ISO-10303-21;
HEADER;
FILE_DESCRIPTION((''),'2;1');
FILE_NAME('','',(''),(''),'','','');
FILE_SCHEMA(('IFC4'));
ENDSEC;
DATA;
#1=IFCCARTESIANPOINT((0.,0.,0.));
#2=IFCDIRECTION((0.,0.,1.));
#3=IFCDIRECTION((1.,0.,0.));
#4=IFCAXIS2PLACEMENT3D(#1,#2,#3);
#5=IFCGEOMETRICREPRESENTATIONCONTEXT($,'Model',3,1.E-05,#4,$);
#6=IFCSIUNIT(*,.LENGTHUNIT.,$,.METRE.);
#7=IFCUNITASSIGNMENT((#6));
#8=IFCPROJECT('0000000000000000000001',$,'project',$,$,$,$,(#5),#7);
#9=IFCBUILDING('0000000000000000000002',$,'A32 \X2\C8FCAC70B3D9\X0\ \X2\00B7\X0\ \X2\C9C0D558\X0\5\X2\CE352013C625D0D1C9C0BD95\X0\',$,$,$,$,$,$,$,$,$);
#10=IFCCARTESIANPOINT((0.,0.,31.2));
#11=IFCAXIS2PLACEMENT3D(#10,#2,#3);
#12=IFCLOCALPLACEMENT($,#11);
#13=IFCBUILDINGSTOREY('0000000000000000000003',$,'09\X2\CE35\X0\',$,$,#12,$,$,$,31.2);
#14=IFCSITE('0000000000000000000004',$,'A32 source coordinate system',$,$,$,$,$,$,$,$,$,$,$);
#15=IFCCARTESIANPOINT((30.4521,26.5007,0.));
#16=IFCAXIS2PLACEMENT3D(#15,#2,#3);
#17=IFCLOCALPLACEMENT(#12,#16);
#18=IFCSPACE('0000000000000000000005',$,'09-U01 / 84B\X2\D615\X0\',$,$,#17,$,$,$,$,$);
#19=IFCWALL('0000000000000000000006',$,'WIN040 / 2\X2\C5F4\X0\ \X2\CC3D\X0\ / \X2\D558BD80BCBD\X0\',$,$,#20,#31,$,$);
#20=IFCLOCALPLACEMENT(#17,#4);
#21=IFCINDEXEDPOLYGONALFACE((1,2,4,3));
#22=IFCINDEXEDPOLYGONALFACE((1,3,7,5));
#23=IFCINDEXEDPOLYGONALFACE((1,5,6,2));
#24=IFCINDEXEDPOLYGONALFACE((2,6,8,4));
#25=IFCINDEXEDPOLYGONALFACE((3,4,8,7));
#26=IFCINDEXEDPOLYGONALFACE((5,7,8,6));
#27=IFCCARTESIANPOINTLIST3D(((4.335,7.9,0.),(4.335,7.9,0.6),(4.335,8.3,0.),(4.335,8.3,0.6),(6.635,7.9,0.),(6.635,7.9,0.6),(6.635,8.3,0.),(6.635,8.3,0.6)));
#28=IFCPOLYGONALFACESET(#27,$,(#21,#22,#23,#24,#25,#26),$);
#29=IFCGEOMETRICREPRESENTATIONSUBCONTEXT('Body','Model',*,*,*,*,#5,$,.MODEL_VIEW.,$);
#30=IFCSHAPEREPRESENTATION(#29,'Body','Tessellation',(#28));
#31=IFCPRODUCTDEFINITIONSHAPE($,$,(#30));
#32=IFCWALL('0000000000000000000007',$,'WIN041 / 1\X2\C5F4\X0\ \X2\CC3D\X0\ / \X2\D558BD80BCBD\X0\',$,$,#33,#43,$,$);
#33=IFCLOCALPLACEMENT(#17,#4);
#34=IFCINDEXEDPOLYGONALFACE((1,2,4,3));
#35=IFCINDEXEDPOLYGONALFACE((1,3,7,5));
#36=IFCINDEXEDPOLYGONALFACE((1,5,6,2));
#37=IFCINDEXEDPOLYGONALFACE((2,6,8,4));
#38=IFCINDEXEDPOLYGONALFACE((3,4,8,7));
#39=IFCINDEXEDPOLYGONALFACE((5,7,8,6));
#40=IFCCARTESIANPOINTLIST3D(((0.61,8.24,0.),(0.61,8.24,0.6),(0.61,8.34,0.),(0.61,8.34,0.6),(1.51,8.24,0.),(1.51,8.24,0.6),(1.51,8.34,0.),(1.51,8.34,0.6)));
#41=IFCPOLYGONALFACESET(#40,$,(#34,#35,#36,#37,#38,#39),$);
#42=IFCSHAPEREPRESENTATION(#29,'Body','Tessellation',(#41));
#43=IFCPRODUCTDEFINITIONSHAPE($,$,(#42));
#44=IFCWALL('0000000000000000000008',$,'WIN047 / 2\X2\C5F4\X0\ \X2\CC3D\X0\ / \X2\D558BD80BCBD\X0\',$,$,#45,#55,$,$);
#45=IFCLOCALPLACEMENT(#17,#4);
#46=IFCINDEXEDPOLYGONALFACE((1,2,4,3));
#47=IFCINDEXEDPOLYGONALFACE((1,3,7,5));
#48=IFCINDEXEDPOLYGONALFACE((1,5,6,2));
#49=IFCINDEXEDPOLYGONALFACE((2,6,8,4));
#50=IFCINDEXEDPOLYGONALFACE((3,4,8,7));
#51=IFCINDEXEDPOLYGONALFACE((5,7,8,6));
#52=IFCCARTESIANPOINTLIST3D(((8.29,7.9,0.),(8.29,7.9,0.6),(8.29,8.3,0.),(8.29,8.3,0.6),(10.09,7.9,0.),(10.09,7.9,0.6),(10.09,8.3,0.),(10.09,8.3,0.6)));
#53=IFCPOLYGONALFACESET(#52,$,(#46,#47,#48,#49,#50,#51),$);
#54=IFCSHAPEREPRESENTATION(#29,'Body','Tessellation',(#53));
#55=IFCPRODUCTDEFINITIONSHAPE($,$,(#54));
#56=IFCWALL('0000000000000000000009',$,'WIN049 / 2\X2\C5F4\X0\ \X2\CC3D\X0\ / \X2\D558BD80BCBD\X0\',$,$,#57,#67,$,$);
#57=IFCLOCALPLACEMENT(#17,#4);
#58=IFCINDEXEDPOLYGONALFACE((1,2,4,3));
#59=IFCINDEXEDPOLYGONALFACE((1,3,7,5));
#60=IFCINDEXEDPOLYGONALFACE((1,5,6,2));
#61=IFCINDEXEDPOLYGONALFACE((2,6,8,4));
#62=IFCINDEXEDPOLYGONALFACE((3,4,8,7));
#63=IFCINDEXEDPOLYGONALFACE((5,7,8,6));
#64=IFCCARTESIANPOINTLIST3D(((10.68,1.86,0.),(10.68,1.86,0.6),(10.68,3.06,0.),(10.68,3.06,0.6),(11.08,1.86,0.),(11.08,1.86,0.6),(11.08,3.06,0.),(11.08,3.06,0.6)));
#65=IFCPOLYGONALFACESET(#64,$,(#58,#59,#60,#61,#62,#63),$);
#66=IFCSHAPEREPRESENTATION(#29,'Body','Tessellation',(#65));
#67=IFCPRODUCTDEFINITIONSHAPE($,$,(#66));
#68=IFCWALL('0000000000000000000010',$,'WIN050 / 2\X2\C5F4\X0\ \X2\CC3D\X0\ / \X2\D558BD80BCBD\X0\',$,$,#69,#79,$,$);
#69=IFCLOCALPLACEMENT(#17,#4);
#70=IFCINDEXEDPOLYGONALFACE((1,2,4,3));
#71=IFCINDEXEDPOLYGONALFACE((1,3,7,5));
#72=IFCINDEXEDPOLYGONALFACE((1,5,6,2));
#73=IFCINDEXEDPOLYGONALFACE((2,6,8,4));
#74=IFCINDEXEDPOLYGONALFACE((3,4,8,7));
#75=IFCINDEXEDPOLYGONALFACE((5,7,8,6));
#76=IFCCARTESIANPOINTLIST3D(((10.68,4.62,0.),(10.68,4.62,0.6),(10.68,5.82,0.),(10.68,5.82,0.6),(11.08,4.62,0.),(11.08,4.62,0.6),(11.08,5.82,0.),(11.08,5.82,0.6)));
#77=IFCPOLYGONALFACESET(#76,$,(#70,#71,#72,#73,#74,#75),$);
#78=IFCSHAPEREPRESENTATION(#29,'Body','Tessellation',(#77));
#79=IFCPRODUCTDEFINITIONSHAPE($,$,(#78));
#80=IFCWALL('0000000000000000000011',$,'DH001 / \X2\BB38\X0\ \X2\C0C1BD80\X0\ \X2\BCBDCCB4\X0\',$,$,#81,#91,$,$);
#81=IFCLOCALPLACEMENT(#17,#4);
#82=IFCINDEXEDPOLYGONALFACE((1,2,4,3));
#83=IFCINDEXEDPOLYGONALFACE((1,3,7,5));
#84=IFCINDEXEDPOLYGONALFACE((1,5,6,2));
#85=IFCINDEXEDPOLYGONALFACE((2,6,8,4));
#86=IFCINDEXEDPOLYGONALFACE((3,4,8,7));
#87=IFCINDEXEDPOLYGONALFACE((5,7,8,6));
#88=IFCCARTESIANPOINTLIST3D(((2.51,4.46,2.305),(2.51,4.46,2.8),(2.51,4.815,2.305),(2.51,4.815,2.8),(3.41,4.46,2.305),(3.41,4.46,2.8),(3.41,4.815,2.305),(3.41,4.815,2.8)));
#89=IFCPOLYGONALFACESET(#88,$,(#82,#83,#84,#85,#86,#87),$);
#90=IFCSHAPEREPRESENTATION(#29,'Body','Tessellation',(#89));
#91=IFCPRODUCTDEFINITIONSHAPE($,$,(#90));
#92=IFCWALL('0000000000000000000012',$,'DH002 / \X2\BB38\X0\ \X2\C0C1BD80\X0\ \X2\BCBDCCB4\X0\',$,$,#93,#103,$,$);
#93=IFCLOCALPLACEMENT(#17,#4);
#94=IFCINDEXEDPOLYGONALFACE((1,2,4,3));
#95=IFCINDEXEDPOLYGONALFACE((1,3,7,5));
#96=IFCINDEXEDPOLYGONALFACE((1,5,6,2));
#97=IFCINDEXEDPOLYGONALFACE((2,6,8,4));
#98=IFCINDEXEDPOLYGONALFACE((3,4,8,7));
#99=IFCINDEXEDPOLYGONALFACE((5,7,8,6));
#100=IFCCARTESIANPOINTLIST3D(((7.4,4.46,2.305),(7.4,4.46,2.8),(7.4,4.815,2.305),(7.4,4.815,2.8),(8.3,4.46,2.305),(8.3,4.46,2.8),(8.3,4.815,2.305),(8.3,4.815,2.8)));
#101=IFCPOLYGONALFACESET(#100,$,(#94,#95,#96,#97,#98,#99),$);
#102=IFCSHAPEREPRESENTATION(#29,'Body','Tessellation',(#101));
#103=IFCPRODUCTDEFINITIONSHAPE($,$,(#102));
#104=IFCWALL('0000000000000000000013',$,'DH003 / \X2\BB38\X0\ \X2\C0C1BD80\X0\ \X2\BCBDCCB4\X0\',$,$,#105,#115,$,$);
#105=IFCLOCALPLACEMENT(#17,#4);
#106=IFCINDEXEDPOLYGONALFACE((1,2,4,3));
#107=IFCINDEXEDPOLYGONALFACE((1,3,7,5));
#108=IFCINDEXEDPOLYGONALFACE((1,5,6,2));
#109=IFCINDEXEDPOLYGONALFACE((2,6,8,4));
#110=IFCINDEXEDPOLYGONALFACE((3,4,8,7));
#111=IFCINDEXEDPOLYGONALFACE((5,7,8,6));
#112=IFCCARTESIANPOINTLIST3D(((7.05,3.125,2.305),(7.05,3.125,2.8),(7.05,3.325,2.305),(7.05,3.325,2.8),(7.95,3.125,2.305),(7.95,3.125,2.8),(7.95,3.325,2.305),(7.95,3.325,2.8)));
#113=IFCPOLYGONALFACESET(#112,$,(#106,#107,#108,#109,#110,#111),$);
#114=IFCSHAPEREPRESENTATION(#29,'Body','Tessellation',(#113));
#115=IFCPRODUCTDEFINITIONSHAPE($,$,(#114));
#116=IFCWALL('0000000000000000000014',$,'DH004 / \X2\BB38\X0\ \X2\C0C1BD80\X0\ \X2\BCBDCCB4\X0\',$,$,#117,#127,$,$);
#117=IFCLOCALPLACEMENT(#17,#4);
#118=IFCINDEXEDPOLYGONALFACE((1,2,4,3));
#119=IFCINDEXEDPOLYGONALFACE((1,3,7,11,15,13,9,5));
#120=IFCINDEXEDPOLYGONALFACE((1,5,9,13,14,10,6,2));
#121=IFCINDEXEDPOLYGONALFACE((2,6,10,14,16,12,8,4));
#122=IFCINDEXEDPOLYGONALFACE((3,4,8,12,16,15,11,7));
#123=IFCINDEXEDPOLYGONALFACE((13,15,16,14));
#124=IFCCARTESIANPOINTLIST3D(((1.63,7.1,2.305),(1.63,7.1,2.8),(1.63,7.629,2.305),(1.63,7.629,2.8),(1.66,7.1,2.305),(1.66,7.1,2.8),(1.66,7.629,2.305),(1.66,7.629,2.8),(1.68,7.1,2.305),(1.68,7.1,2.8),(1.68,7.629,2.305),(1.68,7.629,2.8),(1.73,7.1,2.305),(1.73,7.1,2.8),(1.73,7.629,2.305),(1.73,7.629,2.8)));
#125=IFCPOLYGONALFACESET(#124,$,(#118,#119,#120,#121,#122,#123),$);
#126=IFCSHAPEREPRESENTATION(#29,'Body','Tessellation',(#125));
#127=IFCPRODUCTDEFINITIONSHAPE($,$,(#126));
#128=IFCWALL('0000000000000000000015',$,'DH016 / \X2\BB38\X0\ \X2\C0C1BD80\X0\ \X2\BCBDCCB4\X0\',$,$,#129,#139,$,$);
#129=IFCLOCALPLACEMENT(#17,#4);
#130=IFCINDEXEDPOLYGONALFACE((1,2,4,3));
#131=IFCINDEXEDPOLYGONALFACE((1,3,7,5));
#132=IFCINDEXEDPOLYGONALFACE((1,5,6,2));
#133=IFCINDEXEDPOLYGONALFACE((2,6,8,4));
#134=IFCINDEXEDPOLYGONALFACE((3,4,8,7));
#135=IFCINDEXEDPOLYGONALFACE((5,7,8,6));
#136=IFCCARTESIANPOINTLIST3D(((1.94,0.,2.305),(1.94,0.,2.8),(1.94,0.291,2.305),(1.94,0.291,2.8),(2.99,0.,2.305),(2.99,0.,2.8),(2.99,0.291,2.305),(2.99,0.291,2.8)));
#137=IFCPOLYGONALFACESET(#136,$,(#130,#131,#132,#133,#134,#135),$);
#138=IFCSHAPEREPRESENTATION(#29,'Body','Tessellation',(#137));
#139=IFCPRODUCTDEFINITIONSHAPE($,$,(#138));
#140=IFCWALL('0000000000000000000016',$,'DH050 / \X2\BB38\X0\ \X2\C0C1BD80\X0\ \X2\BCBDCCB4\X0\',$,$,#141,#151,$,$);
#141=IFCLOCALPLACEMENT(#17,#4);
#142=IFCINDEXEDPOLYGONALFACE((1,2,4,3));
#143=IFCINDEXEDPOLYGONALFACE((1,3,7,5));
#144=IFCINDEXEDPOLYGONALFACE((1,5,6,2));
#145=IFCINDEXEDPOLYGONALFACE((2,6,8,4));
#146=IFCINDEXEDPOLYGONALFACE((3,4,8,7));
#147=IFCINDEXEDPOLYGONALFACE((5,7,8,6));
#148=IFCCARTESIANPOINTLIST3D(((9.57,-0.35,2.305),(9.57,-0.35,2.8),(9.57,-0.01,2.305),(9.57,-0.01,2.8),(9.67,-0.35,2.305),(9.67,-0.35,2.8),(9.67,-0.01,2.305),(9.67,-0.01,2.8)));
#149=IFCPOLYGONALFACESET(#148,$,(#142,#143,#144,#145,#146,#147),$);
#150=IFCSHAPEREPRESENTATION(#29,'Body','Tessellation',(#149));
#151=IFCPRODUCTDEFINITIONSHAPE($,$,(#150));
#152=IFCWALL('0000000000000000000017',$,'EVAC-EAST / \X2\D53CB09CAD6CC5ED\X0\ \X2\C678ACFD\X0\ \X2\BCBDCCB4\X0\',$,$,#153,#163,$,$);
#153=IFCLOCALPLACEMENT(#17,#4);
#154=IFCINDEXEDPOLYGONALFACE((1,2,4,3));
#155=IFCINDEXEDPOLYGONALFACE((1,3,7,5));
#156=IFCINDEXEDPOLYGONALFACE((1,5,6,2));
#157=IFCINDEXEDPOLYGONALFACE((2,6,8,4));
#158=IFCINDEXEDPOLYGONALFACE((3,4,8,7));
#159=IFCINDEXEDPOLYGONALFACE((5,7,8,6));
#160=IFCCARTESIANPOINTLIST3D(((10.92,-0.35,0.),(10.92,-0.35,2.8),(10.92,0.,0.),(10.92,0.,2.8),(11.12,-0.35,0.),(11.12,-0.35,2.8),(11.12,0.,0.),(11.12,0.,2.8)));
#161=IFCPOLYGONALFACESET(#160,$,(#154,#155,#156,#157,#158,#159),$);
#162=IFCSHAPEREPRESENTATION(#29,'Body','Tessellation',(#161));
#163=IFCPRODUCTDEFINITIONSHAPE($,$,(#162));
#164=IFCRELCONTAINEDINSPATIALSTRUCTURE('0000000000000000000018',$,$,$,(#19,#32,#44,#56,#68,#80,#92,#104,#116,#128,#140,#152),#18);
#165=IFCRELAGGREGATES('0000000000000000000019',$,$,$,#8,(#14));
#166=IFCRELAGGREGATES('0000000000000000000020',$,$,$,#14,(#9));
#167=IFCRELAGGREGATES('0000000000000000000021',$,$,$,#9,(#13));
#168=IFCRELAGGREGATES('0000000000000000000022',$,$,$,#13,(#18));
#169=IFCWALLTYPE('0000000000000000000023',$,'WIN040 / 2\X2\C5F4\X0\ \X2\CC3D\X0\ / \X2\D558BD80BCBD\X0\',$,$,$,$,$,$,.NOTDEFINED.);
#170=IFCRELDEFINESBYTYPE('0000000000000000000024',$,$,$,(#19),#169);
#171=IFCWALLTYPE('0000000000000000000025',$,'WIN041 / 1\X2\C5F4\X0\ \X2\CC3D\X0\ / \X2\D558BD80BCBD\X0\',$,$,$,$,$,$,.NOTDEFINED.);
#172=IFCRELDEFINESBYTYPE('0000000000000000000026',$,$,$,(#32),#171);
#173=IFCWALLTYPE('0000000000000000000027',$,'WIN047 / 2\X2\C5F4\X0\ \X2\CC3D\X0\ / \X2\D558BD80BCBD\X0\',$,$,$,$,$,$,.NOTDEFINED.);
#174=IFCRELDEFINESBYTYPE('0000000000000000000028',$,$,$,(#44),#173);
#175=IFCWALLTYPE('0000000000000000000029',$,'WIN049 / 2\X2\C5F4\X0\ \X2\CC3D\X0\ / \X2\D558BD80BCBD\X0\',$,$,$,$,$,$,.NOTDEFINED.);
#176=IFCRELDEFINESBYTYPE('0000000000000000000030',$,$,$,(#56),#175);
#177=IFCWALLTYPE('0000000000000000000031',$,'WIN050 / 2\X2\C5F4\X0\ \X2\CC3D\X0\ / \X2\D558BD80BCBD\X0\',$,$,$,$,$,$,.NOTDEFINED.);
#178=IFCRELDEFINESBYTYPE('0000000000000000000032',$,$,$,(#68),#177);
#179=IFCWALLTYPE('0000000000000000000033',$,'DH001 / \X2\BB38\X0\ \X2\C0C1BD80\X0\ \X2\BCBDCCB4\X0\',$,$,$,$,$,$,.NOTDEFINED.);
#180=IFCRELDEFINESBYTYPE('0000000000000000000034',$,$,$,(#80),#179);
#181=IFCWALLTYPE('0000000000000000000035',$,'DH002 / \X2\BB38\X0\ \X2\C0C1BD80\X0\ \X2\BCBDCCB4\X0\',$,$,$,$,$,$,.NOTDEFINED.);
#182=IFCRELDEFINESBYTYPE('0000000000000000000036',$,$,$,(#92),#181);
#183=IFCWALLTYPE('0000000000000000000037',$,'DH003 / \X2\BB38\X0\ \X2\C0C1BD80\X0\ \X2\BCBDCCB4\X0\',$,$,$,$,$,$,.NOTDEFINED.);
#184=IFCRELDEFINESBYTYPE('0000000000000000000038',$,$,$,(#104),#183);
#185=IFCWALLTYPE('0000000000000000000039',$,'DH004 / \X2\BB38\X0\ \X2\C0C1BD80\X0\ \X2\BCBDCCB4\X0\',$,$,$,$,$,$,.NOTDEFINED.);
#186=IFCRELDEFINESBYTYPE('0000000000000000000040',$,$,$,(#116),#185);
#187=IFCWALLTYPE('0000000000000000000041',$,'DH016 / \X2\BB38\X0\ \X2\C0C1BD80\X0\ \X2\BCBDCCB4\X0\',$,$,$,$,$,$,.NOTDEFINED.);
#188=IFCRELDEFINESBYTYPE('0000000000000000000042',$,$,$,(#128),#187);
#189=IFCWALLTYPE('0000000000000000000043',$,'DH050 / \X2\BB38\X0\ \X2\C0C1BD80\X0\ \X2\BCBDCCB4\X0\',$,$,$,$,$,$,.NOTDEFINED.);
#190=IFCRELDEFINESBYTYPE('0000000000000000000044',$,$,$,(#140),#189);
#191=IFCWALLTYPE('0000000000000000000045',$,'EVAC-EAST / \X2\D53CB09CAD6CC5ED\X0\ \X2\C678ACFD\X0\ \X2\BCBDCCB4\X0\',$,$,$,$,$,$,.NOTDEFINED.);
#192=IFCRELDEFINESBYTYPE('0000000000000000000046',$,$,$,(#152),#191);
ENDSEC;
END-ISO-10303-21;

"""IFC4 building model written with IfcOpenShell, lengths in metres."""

from ifc_helpers import new_model, si_unit, frame, origin, origin_with_axes, place, context, subcontext, project, spatial, polyline, outline, extrude, source, transform, mapped, type_object, type_shapes, element, save


model = new_model("IFC4")

# Units and contexts
model_context = context("Model", 3, precision=1e-05, world=origin_with_axes())
body_context = subcontext(model_context, "Body", "Model", "MODEL_VIEW")
ifc_project = project(units=[si_unit("LENGTHUNIT", "METRE")], contexts=[model_context])

# Site, building, storey, space
site = spatial("IfcSite", under=ifc_project, Name="A32 source coordinate system")
building = spatial("IfcBuilding", under=site, Name="A32 주거동 · 지하5층–옥탑지붕")
storey_placement = place(None, frame((0.0, 0.0, 31.2), z_axis=(0.0, 0.0, 1.0), x_axis=(1.0, 0.0, 0.0)))
storey = spatial("IfcBuildingStorey", under=building, at=storey_placement, Name="09층", Elevation=31.2)
space_placement = place(storey_placement, frame((30.4521, 26.5007, 0.0), z_axis=(0.0, 0.0, 1.0), x_axis=(1.0, 0.0, 0.0)))
space = spatial("IfcSpace", under=storey, at=space_placement, Name="09-U01 / 84B형")

# Walls
wall_type_1 = type_object("IfcWallType", Name="WIN040 / 2열 창 / 하부벽", PredefinedType="NOTDEFINED")
shared_shape_1 = source(origin(), body_context, "Body", "SweptSolid", [
    extrude(outline(polyline([(4.335, 8.3), (6.635, 8.3), (6.635, 7.9), (4.335, 7.9), (4.335, 8.3)])), origin(), (0.0, 0.0, 1.0), 0.6),
])
type_shapes(wall_type_1, [shared_shape_1])
wall_1_placement = place(space_placement, origin_with_axes())
element("IfcWall", 1, at=wall_1_placement, inside=space, type_object=wall_type_1, Name="WIN040 / 2열 창 / 하부벽", context=body_context, shape_type="MappedRepresentation", body=[
    mapped(shared_shape_1, transform((0.0, 0.0, 0.0), scale=1.0)),
])
wall_type_2 = type_object("IfcWallType", Name="WIN041 / 1열 창 / 하부벽", PredefinedType="NOTDEFINED")
shared_shape_2 = source(origin(), body_context, "Body", "SweptSolid", [
    extrude(outline(polyline([(0.61, 8.34), (1.51, 8.34), (1.51, 8.24), (0.61, 8.24), (0.61, 8.34)])), origin(), (0.0, 0.0, 1.0), 0.6),
])
type_shapes(wall_type_2, [shared_shape_2])
wall_2_placement = place(space_placement, origin_with_axes())
element("IfcWall", 2, at=wall_2_placement, inside=space, type_object=wall_type_2, Name="WIN041 / 1열 창 / 하부벽", context=body_context, shape_type="MappedRepresentation", body=[
    mapped(shared_shape_2, transform((0.0, 0.0, 0.0), scale=1.0)),
])
wall_type_3 = type_object("IfcWallType", Name="WIN047 / 2열 창 / 하부벽", PredefinedType="NOTDEFINED")
shared_shape_3 = source(origin(), body_context, "Body", "SweptSolid", [
    extrude(outline(polyline([(8.29, 8.3), (10.09, 8.3), (10.09, 7.9), (8.29, 7.9), (8.29, 8.3)])), origin(), (0.0, 0.0, 1.0), 0.6),
])
type_shapes(wall_type_3, [shared_shape_3])
wall_3_placement = place(space_placement, origin_with_axes())
element("IfcWall", 3, at=wall_3_placement, inside=space, type_object=wall_type_3, Name="WIN047 / 2열 창 / 하부벽", context=body_context, shape_type="MappedRepresentation", body=[
    mapped(shared_shape_3, transform((0.0, 0.0, 0.0), scale=1.0)),
])
wall_type_4 = type_object("IfcWallType", Name="WIN049 / 2열 창 / 하부벽", PredefinedType="NOTDEFINED")
shared_shape_4 = source(origin(), body_context, "Body", "SweptSolid", [
    extrude(outline(polyline([(10.68, 3.06), (11.08, 3.06), (11.08, 1.86), (10.68, 1.86), (10.68, 3.06)])), origin(), (0.0, 0.0, 1.0), 0.6),
])
type_shapes(wall_type_4, [shared_shape_4])
wall_4_placement = place(space_placement, origin_with_axes())
element("IfcWall", 4, at=wall_4_placement, inside=space, type_object=wall_type_4, Name="WIN049 / 2열 창 / 하부벽", context=body_context, shape_type="MappedRepresentation", body=[
    mapped(shared_shape_4, transform((0.0, 0.0, 0.0), scale=1.0)),
])
wall_type_5 = type_object("IfcWallType", Name="WIN050 / 2열 창 / 하부벽", PredefinedType="NOTDEFINED")
shared_shape_5 = source(origin(), body_context, "Body", "SweptSolid", [
    extrude(outline(polyline([(10.68, 5.82), (11.08, 5.82), (11.08, 4.62), (10.68, 4.62), (10.68, 5.82)])), origin(), (0.0, 0.0, 1.0), 0.6),
])
type_shapes(wall_type_5, [shared_shape_5])
wall_5_placement = place(space_placement, origin_with_axes())
element("IfcWall", 5, at=wall_5_placement, inside=space, type_object=wall_type_5, Name="WIN050 / 2열 창 / 하부벽", context=body_context, shape_type="MappedRepresentation", body=[
    mapped(shared_shape_5, transform((0.0, 0.0, 0.0), scale=1.0)),
])
wall_type_6 = type_object("IfcWallType", Name="DH001 / 문 상부 벽체", PredefinedType="NOTDEFINED")
shared_shape_6 = source(origin(), body_context, "Body", "SweptSolid", [
    extrude(outline(polyline([(3.41, 4.815), (3.41, 4.46), (2.51, 4.46), (2.51, 4.815), (3.41, 4.815)])), frame((0.0, 0.0, 2.305)), (0.0, 0.0, 1.0), 0.495),
])
type_shapes(wall_type_6, [shared_shape_6])
wall_6_placement = place(space_placement, origin_with_axes())
element("IfcWall", 6, at=wall_6_placement, inside=space, type_object=wall_type_6, Name="DH001 / 문 상부 벽체", context=body_context, shape_type="MappedRepresentation", body=[
    mapped(shared_shape_6, transform((0.0, 0.0, 0.0), scale=1.0)),
])
wall_type_7 = type_object("IfcWallType", Name="DH002 / 문 상부 벽체", PredefinedType="NOTDEFINED")
shared_shape_7 = source(origin(), body_context, "Body", "SweptSolid", [
    extrude(outline(polyline([(8.3, 4.815), (8.3, 4.46), (7.4, 4.46), (7.4, 4.815), (8.3, 4.815)])), frame((0.0, 0.0, 2.305)), (0.0, 0.0, 1.0), 0.495),
])
type_shapes(wall_type_7, [shared_shape_7])
wall_7_placement = place(space_placement, origin_with_axes())
element("IfcWall", 7, at=wall_7_placement, inside=space, type_object=wall_type_7, Name="DH002 / 문 상부 벽체", context=body_context, shape_type="MappedRepresentation", body=[
    mapped(shared_shape_7, transform((0.0, 0.0, 0.0), scale=1.0)),
])
wall_type_8 = type_object("IfcWallType", Name="DH003 / 문 상부 벽체", PredefinedType="NOTDEFINED")
shared_shape_8 = source(origin(), body_context, "Body", "SweptSolid", [
    extrude(outline(polyline([(7.95, 3.325), (7.95, 3.125), (7.05, 3.125), (7.05, 3.325), (7.95, 3.325)])), frame((0.0, 0.0, 2.305)), (0.0, 0.0, 1.0), 0.495),
])
type_shapes(wall_type_8, [shared_shape_8])
wall_8_placement = place(space_placement, origin_with_axes())
element("IfcWall", 8, at=wall_8_placement, inside=space, type_object=wall_type_8, Name="DH003 / 문 상부 벽체", context=body_context, shape_type="MappedRepresentation", body=[
    mapped(shared_shape_8, transform((0.0, 0.0, 0.0), scale=1.0)),
])
wall_type_9 = type_object("IfcWallType", Name="DH004 / 문 상부 벽체", PredefinedType="NOTDEFINED")
shared_shape_9 = source(origin(), body_context, "Body", "SweptSolid", [
    extrude(outline(polyline([(1.66, 7.1), (1.63, 7.1), (1.63, 7.629), (1.66, 7.629), (1.68, 7.629), (1.73, 7.629), (1.73, 7.1), (1.68, 7.1), (1.66, 7.1)])), frame((0.0, 0.0, 2.305)), (0.0, 0.0, 1.0), 0.495),
])
type_shapes(wall_type_9, [shared_shape_9])
wall_9_placement = place(space_placement, origin_with_axes())
element("IfcWall", 9, at=wall_9_placement, inside=space, type_object=wall_type_9, Name="DH004 / 문 상부 벽체", context=body_context, shape_type="MappedRepresentation", body=[
    mapped(shared_shape_9, transform((0.0, 0.0, 0.0), scale=1.0)),
])
wall_type_10 = type_object("IfcWallType", Name="DH016 / 문 상부 벽체", PredefinedType="NOTDEFINED")
shared_shape_10 = source(origin(), body_context, "Body", "SweptSolid", [
    extrude(outline(polyline([(2.99, 0.291), (2.99, 0.0), (1.94, 0.0), (1.94, 0.291), (2.99, 0.291)])), frame((0.0, 0.0, 2.305)), (0.0, 0.0, 1.0), 0.495),
])
type_shapes(wall_type_10, [shared_shape_10])
wall_10_placement = place(space_placement, origin_with_axes())
element("IfcWall", 10, at=wall_10_placement, inside=space, type_object=wall_type_10, Name="DH016 / 문 상부 벽체", context=body_context, shape_type="MappedRepresentation", body=[
    mapped(shared_shape_10, transform((0.0, 0.0, 0.0), scale=1.0)),
])
wall_type_11 = type_object("IfcWallType", Name="DH050 / 문 상부 벽체", PredefinedType="NOTDEFINED")
shared_shape_11 = source(origin(), body_context, "Body", "SweptSolid", [
    extrude(outline(polyline([(9.67, -0.01), (9.67, -0.35), (9.57, -0.35), (9.57, -0.01), (9.67, -0.01)])), frame((0.0, 0.0, 2.305)), (0.0, 0.0, 1.0), 0.495),
])
type_shapes(wall_type_11, [shared_shape_11])
wall_11_placement = place(space_placement, origin_with_axes())
element("IfcWall", 11, at=wall_11_placement, inside=space, type_object=wall_type_11, Name="DH050 / 문 상부 벽체", context=body_context, shape_type="MappedRepresentation", body=[
    mapped(shared_shape_11, transform((0.0, 0.0, 0.0), scale=1.0)),
])
wall_type_12 = type_object("IfcWallType", Name="EVAC-EAST / 피난구역 외곽 벽체", PredefinedType="NOTDEFINED")
shared_shape_12 = source(origin(), body_context, "Body", "SweptSolid", [
    extrude(outline(polyline([(10.92, 0.0), (11.12, 0.0), (11.12, -0.35), (10.92, -0.35), (10.92, 0.0)])), origin(), (0.0, 0.0, 1.0), 2.8),
])
type_shapes(wall_type_12, [shared_shape_12])
wall_12_placement = place(space_placement, origin_with_axes())
element("IfcWall", 12, at=wall_12_placement, inside=space, type_object=wall_type_12, Name="EVAC-EAST / 피난구역 외곽 벽체", context=body_context, shape_type="MappedRepresentation", body=[
    mapped(shared_shape_12, transform((0.0, 0.0, 0.0), scale=1.0)),
])

save(model, "model.ifc")
